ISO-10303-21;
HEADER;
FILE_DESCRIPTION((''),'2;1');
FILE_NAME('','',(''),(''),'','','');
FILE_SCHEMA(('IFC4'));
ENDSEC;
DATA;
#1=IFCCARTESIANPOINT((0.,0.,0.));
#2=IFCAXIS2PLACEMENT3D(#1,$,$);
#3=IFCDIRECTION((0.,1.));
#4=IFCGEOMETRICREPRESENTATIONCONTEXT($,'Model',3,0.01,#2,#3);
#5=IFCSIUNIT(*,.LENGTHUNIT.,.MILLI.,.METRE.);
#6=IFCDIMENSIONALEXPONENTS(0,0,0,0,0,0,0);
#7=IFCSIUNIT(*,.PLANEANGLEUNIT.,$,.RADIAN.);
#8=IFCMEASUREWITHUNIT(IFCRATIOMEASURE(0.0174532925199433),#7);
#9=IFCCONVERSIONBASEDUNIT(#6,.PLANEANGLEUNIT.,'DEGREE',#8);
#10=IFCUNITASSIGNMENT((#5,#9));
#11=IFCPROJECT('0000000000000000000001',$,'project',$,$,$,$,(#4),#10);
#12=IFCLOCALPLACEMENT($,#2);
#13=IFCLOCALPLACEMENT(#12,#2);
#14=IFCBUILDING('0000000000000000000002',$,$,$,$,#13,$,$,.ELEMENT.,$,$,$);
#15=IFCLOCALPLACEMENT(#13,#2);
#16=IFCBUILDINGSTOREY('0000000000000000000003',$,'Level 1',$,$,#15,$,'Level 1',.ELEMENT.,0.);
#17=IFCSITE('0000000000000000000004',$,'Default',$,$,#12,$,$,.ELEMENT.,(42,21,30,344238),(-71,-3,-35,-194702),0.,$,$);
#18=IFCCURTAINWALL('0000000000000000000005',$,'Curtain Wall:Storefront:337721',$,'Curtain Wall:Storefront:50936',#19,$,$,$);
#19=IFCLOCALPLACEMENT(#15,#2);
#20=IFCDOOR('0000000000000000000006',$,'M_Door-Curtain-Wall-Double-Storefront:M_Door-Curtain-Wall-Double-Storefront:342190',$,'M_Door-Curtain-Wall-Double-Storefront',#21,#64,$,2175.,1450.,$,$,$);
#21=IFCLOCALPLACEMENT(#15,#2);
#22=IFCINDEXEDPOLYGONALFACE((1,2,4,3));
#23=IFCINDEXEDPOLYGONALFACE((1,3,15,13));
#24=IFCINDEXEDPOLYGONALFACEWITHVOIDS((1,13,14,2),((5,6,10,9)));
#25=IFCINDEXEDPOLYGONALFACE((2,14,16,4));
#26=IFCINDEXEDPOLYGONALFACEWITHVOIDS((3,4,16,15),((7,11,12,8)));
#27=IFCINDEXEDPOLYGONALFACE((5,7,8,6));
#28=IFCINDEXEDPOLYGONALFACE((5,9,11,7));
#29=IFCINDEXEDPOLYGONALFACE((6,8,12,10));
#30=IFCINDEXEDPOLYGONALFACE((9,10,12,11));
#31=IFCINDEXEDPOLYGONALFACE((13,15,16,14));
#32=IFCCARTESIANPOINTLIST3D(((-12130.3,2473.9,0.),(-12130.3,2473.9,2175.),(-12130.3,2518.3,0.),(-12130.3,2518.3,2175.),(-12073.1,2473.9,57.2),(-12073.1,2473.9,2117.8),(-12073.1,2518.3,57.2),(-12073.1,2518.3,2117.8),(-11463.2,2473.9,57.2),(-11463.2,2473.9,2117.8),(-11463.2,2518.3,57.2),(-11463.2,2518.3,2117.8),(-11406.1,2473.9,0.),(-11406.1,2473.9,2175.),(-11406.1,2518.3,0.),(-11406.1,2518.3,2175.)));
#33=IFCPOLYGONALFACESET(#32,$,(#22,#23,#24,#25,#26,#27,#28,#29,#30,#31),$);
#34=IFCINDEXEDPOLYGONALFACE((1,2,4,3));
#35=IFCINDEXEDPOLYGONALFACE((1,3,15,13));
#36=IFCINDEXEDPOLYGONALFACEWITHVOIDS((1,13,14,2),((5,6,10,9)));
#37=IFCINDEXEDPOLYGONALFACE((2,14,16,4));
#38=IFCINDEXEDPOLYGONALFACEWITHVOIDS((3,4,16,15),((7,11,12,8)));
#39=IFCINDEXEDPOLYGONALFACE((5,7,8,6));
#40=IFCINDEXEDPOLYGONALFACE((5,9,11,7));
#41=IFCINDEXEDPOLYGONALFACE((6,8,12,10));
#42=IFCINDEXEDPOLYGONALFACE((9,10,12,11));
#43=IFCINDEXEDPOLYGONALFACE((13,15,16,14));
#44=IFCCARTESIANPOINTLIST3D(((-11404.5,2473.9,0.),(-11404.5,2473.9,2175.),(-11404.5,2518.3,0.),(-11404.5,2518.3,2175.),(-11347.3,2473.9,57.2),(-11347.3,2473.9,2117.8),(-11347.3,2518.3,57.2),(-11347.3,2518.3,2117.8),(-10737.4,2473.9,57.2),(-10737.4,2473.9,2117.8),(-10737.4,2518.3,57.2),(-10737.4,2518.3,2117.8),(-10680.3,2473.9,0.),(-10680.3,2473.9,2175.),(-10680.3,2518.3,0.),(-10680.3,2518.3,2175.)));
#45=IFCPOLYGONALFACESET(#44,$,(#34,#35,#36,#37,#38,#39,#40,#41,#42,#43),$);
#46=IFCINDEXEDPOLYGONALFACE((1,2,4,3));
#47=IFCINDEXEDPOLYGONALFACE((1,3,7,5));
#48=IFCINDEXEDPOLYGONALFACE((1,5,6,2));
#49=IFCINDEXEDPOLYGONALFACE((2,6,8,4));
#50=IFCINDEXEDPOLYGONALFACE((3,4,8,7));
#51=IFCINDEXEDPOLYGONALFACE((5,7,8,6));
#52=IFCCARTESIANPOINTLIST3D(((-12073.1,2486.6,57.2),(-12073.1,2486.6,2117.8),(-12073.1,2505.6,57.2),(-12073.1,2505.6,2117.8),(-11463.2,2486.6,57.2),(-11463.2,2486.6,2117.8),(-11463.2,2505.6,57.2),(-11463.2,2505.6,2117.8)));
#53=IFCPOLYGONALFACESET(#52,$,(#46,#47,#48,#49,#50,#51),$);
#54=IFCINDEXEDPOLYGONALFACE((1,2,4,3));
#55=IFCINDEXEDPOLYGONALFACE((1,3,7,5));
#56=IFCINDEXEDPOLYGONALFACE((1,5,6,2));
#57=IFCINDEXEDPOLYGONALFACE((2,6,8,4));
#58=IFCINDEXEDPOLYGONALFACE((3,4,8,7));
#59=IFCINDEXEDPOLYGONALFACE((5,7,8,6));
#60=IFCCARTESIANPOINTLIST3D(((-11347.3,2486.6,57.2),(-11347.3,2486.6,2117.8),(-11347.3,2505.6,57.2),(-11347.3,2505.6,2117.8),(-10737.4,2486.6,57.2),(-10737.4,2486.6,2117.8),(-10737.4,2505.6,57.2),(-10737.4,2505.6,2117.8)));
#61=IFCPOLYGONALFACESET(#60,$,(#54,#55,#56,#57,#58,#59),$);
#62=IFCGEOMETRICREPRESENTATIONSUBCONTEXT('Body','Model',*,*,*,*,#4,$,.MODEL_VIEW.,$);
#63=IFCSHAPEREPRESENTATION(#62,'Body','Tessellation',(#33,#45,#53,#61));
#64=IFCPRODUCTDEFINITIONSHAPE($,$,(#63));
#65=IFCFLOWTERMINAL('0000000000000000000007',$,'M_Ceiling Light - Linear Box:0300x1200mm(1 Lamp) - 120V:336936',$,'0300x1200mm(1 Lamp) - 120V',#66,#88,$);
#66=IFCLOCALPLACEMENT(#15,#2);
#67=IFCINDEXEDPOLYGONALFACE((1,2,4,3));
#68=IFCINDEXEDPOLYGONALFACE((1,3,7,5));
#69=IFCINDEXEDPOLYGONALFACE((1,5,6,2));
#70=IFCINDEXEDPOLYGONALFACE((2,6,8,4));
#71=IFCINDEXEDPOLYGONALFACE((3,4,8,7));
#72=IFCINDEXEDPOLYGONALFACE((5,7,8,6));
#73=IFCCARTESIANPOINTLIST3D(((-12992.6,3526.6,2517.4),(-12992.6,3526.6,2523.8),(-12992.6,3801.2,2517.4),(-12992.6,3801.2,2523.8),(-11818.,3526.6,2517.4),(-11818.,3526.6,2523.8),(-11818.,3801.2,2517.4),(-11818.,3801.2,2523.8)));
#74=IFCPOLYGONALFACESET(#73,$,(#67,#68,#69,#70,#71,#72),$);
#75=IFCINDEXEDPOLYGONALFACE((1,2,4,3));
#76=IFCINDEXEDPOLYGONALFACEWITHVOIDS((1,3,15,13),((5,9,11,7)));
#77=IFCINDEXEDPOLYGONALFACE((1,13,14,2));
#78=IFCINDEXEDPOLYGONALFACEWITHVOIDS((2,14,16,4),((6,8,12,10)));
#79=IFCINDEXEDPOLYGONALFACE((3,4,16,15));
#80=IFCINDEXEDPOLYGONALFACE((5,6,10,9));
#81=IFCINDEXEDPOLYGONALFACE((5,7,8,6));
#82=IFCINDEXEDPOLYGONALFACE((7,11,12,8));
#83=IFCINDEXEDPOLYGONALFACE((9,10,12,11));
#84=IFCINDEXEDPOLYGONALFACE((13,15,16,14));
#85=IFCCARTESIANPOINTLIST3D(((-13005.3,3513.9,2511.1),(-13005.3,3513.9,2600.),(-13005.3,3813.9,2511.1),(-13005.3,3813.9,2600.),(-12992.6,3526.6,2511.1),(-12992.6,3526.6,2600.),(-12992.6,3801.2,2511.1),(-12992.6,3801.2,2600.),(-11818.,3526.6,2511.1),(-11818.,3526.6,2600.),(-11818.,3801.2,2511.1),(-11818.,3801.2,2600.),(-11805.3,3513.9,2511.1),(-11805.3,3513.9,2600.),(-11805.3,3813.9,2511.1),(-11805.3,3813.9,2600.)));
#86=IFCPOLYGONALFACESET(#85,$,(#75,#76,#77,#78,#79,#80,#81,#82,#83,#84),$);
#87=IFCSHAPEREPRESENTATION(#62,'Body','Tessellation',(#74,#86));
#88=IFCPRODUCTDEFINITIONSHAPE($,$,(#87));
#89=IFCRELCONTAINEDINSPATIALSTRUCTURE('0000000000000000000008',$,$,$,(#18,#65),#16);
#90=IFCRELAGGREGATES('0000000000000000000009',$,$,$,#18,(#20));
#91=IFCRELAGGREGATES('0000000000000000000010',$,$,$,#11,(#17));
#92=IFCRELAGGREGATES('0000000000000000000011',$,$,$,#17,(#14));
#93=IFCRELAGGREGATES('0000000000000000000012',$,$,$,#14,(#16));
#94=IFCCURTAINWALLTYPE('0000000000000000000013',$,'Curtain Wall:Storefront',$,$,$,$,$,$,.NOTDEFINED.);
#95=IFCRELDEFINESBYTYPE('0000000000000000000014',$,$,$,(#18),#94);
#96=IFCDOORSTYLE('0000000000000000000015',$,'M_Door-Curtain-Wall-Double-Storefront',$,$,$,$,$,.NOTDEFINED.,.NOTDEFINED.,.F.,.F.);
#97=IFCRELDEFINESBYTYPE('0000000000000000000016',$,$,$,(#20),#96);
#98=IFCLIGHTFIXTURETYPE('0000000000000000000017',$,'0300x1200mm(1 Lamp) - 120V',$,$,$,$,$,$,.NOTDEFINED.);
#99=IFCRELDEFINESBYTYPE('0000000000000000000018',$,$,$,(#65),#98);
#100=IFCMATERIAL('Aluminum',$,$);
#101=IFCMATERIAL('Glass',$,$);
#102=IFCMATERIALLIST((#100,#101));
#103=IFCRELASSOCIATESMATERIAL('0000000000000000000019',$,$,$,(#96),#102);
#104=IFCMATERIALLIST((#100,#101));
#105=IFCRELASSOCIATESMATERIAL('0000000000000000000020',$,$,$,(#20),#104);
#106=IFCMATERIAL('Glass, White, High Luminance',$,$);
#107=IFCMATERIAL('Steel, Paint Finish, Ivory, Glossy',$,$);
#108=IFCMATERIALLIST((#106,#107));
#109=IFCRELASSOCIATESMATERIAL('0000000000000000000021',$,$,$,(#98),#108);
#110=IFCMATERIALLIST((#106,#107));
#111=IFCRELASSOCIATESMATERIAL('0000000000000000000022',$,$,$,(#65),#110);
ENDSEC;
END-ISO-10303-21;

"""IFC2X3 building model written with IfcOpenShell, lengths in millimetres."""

from ifc_helpers import new_model, entity, si_unit, converted_unit, direction, frame, frame_2d, origin, origin_2d_with_axis, place, context, subcontext, project, spatial, polyline, rectangle, outline, extrude, source, transform, mapped, material, material_list, type_object, type_shapes, element, aggregate, save


model = new_model("IFC2X3")

# Units and contexts
model_context = context("Model", 3, precision=0.01, world=origin(), true_north=direction((0.0, 1.0)))
body_context = subcontext(model_context, "Body", "Model", "MODEL_VIEW")
ifc_project = project(units=[si_unit("LENGTHUNIT", "METRE", prefix="MILLI"), converted_unit("PLANEANGLEUNIT", "DEGREE", entity("IfcRatioMeasure", 0.0174532925199433), si_unit("PLANEANGLEUNIT", "RADIAN"), dimensions=[0, 0, 0, 0, 0, 0, 0])], contexts=[model_context])

# Site, building, storey
site_placement = place(None, origin())
site = spatial("IfcSite", under=ifc_project, at=site_placement, Name="Default", CompositionType="ELEMENT", RefLatitude=(42, 21, 30, 344238), RefLongitude=(-71, -3, -35, -194702), RefElevation=0.0)
building_placement = place(site_placement, origin())
building = spatial("IfcBuilding", under=site, at=building_placement, CompositionType="ELEMENT")
storey_placement = place(building_placement, origin())
storey = spatial("IfcBuildingStorey", under=building, at=storey_placement, Name="Level 1", LongName="Level 1", CompositionType="ELEMENT", Elevation=0.0)

# Curtain wall
curtain_wall_type = type_object("IfcCurtainWallType", Name="Curtain Wall:Storefront", PredefinedType="NOTDEFINED")
curtain_wall_placement = place(storey_placement, origin())
curtain_wall = element("IfcCurtainWall", 1, at=curtain_wall_placement, inside=storey, type_object=curtain_wall_type, Name="Curtain Wall:Storefront:337721", ObjectType="Curtain Wall:Storefront:50936")
ifc_material_1 = material(Name="Aluminum")
ifc_material_2 = material(Name="Glass")

# Door
ifc_material_list_1 = material_list([ifc_material_1, ifc_material_2])
ifc_material_list_2 = material_list([ifc_material_1, ifc_material_2])
door_style = type_object("IfcDoorStyle", Name="M_Door-Curtain-Wall-Double-Storefront", ConstructionType="NOTDEFINED", OperationType="NOTDEFINED", ParameterTakesPrecedence=False, Sizeable=False, material=ifc_material_list_2)
shared_shape_1 = source(origin(), body_context, "Body", "SweptSolid", [
    extrude(outline(polyline([(-1087.5, -362.1), (1087.5, -362.1), (1087.5, 362.1), (-1087.5, 362.1), (-1087.5, -362.1)]), holes=[polyline([(-1030.3, 305.0), (1030.3, 305.0), (1030.3, -305.0), (-1030.3, -305.0), (-1030.3, 305.0)])]), frame((-362.9, -60.0, 1087.5), z_axis=(0.0, 1.0, 0.0), x_axis=(0.0, 0.0, -1.0)), (0.0, 0.0, 1.0), 44.5),
    extrude(outline(polyline([(-362.1, -1087.5), (362.1, -1087.5), (362.1, 1087.5), (-362.1, 1087.5), (-362.1, -1087.5)]), holes=[polyline([(-304.9, -1030.3), (-304.9, 1030.3), (304.9, 1030.3), (304.9, -1030.3), (-304.9, -1030.3)])]), frame((362.9, -60.0, 1087.5), z_axis=(0.0, 1.0, 0.0), x_axis=(1.0, 0.0, 0.0)), (0.0, 0.0, 1.0), 44.5),
    extrude(rectangle(XDim=609.9, YDim=19.0, at=frame_2d((0.0, 0.0), x_axis=(1.0, 0.0))), frame((-362.9, -37.8, 57.1), z_axis=(0.0, 0.0, 1.0), x_axis=(-1.0, 0.0, 0.0)), (0.0, 0.0, 1.0), 2060.7),
    extrude(rectangle(XDim=609.9, YDim=19.0, at=frame_2d((0.0, 0.0), x_axis=(1.0, 0.0))), frame((362.9, -37.8, 57.1), z_axis=(0.0, 0.0, 1.0), x_axis=(-1.0, 0.0, 0.0)), (0.0, 0.0, 1.0), 2060.7),
])
type_shapes(door_style, [shared_shape_1])
door_placement = place(curtain_wall_placement, frame((-11405.3, 2533.9, 0.0)))
door = element("IfcDoor", 2, at=door_placement, type_object=door_style, material=ifc_material_list_1, Name="M_Door-Curtain-Wall-Double-Storefront:M_Door-Curtain-Wall-Double-Storefront:342190", ObjectType="M_Door-Curtain-Wall-Double-Storefront", OverallHeight=2175.0, OverallWidth=1450.0, context=body_context, shape_type="MappedRepresentation", body=[
    mapped(shared_shape_1, transform((0.0, 0.0, 0.0), scale=1.0)),
])
aggregate(curtain_wall, [door])

# Flow terminal
ifc_material_3 = material(Name="Glass, White, High Luminance")
ifc_material_4 = material(Name="Steel, Paint Finish, Ivory, Glossy")
ifc_material_list_3 = material_list([ifc_material_3, ifc_material_4])
ifc_material_list_4 = material_list([ifc_material_3, ifc_material_4])
light_fixture_type = type_object("IfcLightFixtureType", Name="0300x1200mm(1 Lamp) - 120V", PredefinedType="NOTDEFINED", material=ifc_material_list_4)
shared_shape_2 = source(origin(), body_context, "Body", "SweptSolid", [
    extrude(rectangle(XDim=1174.6, YDim=274.6, at=origin_2d_with_axis()), frame((0.0, 0.0, 2355.8), z_axis=(0.0, 0.0, 1.0), x_axis=(-1.0, 0.0, 0.0)), (0.0, 0.0, 1.0), 6.4),
    extrude(outline(polyline([(-600.0, -150.0), (600.0, -150.0), (600.0, 150.0), (-600.0, 150.0), (-600.0, -150.0)]), holes=[polyline([(-587.3, -137.3), (-587.3, 137.3), (587.3, 137.3), (587.3, -137.3), (-587.3, -137.3)])]), frame((0.0, 0.0, 2349.5), z_axis=(0.0, 0.0, 1.0), x_axis=(-1.0, 0.0, 0.0)), (0.0, 0.0, 1.0), 88.9),
])
type_shapes(light_fixture_type, [shared_shape_2])
flow_terminal_placement = place(storey_placement, frame((-12405.3, 3663.9, 161.6)))
element("IfcFlowTerminal", 3, at=flow_terminal_placement, inside=storey, type_object=light_fixture_type, material=ifc_material_list_3, Name="M_Ceiling Light - Linear Box:0300x1200mm(1 Lamp) - 120V:336936", ObjectType="0300x1200mm(1 Lamp) - 120V", context=body_context, shape_type="MappedRepresentation", body=[
    mapped(shared_shape_2, transform((0.0, 0.0, 0.0), scale=1.0)),
])

save(model, "model.ifc")
